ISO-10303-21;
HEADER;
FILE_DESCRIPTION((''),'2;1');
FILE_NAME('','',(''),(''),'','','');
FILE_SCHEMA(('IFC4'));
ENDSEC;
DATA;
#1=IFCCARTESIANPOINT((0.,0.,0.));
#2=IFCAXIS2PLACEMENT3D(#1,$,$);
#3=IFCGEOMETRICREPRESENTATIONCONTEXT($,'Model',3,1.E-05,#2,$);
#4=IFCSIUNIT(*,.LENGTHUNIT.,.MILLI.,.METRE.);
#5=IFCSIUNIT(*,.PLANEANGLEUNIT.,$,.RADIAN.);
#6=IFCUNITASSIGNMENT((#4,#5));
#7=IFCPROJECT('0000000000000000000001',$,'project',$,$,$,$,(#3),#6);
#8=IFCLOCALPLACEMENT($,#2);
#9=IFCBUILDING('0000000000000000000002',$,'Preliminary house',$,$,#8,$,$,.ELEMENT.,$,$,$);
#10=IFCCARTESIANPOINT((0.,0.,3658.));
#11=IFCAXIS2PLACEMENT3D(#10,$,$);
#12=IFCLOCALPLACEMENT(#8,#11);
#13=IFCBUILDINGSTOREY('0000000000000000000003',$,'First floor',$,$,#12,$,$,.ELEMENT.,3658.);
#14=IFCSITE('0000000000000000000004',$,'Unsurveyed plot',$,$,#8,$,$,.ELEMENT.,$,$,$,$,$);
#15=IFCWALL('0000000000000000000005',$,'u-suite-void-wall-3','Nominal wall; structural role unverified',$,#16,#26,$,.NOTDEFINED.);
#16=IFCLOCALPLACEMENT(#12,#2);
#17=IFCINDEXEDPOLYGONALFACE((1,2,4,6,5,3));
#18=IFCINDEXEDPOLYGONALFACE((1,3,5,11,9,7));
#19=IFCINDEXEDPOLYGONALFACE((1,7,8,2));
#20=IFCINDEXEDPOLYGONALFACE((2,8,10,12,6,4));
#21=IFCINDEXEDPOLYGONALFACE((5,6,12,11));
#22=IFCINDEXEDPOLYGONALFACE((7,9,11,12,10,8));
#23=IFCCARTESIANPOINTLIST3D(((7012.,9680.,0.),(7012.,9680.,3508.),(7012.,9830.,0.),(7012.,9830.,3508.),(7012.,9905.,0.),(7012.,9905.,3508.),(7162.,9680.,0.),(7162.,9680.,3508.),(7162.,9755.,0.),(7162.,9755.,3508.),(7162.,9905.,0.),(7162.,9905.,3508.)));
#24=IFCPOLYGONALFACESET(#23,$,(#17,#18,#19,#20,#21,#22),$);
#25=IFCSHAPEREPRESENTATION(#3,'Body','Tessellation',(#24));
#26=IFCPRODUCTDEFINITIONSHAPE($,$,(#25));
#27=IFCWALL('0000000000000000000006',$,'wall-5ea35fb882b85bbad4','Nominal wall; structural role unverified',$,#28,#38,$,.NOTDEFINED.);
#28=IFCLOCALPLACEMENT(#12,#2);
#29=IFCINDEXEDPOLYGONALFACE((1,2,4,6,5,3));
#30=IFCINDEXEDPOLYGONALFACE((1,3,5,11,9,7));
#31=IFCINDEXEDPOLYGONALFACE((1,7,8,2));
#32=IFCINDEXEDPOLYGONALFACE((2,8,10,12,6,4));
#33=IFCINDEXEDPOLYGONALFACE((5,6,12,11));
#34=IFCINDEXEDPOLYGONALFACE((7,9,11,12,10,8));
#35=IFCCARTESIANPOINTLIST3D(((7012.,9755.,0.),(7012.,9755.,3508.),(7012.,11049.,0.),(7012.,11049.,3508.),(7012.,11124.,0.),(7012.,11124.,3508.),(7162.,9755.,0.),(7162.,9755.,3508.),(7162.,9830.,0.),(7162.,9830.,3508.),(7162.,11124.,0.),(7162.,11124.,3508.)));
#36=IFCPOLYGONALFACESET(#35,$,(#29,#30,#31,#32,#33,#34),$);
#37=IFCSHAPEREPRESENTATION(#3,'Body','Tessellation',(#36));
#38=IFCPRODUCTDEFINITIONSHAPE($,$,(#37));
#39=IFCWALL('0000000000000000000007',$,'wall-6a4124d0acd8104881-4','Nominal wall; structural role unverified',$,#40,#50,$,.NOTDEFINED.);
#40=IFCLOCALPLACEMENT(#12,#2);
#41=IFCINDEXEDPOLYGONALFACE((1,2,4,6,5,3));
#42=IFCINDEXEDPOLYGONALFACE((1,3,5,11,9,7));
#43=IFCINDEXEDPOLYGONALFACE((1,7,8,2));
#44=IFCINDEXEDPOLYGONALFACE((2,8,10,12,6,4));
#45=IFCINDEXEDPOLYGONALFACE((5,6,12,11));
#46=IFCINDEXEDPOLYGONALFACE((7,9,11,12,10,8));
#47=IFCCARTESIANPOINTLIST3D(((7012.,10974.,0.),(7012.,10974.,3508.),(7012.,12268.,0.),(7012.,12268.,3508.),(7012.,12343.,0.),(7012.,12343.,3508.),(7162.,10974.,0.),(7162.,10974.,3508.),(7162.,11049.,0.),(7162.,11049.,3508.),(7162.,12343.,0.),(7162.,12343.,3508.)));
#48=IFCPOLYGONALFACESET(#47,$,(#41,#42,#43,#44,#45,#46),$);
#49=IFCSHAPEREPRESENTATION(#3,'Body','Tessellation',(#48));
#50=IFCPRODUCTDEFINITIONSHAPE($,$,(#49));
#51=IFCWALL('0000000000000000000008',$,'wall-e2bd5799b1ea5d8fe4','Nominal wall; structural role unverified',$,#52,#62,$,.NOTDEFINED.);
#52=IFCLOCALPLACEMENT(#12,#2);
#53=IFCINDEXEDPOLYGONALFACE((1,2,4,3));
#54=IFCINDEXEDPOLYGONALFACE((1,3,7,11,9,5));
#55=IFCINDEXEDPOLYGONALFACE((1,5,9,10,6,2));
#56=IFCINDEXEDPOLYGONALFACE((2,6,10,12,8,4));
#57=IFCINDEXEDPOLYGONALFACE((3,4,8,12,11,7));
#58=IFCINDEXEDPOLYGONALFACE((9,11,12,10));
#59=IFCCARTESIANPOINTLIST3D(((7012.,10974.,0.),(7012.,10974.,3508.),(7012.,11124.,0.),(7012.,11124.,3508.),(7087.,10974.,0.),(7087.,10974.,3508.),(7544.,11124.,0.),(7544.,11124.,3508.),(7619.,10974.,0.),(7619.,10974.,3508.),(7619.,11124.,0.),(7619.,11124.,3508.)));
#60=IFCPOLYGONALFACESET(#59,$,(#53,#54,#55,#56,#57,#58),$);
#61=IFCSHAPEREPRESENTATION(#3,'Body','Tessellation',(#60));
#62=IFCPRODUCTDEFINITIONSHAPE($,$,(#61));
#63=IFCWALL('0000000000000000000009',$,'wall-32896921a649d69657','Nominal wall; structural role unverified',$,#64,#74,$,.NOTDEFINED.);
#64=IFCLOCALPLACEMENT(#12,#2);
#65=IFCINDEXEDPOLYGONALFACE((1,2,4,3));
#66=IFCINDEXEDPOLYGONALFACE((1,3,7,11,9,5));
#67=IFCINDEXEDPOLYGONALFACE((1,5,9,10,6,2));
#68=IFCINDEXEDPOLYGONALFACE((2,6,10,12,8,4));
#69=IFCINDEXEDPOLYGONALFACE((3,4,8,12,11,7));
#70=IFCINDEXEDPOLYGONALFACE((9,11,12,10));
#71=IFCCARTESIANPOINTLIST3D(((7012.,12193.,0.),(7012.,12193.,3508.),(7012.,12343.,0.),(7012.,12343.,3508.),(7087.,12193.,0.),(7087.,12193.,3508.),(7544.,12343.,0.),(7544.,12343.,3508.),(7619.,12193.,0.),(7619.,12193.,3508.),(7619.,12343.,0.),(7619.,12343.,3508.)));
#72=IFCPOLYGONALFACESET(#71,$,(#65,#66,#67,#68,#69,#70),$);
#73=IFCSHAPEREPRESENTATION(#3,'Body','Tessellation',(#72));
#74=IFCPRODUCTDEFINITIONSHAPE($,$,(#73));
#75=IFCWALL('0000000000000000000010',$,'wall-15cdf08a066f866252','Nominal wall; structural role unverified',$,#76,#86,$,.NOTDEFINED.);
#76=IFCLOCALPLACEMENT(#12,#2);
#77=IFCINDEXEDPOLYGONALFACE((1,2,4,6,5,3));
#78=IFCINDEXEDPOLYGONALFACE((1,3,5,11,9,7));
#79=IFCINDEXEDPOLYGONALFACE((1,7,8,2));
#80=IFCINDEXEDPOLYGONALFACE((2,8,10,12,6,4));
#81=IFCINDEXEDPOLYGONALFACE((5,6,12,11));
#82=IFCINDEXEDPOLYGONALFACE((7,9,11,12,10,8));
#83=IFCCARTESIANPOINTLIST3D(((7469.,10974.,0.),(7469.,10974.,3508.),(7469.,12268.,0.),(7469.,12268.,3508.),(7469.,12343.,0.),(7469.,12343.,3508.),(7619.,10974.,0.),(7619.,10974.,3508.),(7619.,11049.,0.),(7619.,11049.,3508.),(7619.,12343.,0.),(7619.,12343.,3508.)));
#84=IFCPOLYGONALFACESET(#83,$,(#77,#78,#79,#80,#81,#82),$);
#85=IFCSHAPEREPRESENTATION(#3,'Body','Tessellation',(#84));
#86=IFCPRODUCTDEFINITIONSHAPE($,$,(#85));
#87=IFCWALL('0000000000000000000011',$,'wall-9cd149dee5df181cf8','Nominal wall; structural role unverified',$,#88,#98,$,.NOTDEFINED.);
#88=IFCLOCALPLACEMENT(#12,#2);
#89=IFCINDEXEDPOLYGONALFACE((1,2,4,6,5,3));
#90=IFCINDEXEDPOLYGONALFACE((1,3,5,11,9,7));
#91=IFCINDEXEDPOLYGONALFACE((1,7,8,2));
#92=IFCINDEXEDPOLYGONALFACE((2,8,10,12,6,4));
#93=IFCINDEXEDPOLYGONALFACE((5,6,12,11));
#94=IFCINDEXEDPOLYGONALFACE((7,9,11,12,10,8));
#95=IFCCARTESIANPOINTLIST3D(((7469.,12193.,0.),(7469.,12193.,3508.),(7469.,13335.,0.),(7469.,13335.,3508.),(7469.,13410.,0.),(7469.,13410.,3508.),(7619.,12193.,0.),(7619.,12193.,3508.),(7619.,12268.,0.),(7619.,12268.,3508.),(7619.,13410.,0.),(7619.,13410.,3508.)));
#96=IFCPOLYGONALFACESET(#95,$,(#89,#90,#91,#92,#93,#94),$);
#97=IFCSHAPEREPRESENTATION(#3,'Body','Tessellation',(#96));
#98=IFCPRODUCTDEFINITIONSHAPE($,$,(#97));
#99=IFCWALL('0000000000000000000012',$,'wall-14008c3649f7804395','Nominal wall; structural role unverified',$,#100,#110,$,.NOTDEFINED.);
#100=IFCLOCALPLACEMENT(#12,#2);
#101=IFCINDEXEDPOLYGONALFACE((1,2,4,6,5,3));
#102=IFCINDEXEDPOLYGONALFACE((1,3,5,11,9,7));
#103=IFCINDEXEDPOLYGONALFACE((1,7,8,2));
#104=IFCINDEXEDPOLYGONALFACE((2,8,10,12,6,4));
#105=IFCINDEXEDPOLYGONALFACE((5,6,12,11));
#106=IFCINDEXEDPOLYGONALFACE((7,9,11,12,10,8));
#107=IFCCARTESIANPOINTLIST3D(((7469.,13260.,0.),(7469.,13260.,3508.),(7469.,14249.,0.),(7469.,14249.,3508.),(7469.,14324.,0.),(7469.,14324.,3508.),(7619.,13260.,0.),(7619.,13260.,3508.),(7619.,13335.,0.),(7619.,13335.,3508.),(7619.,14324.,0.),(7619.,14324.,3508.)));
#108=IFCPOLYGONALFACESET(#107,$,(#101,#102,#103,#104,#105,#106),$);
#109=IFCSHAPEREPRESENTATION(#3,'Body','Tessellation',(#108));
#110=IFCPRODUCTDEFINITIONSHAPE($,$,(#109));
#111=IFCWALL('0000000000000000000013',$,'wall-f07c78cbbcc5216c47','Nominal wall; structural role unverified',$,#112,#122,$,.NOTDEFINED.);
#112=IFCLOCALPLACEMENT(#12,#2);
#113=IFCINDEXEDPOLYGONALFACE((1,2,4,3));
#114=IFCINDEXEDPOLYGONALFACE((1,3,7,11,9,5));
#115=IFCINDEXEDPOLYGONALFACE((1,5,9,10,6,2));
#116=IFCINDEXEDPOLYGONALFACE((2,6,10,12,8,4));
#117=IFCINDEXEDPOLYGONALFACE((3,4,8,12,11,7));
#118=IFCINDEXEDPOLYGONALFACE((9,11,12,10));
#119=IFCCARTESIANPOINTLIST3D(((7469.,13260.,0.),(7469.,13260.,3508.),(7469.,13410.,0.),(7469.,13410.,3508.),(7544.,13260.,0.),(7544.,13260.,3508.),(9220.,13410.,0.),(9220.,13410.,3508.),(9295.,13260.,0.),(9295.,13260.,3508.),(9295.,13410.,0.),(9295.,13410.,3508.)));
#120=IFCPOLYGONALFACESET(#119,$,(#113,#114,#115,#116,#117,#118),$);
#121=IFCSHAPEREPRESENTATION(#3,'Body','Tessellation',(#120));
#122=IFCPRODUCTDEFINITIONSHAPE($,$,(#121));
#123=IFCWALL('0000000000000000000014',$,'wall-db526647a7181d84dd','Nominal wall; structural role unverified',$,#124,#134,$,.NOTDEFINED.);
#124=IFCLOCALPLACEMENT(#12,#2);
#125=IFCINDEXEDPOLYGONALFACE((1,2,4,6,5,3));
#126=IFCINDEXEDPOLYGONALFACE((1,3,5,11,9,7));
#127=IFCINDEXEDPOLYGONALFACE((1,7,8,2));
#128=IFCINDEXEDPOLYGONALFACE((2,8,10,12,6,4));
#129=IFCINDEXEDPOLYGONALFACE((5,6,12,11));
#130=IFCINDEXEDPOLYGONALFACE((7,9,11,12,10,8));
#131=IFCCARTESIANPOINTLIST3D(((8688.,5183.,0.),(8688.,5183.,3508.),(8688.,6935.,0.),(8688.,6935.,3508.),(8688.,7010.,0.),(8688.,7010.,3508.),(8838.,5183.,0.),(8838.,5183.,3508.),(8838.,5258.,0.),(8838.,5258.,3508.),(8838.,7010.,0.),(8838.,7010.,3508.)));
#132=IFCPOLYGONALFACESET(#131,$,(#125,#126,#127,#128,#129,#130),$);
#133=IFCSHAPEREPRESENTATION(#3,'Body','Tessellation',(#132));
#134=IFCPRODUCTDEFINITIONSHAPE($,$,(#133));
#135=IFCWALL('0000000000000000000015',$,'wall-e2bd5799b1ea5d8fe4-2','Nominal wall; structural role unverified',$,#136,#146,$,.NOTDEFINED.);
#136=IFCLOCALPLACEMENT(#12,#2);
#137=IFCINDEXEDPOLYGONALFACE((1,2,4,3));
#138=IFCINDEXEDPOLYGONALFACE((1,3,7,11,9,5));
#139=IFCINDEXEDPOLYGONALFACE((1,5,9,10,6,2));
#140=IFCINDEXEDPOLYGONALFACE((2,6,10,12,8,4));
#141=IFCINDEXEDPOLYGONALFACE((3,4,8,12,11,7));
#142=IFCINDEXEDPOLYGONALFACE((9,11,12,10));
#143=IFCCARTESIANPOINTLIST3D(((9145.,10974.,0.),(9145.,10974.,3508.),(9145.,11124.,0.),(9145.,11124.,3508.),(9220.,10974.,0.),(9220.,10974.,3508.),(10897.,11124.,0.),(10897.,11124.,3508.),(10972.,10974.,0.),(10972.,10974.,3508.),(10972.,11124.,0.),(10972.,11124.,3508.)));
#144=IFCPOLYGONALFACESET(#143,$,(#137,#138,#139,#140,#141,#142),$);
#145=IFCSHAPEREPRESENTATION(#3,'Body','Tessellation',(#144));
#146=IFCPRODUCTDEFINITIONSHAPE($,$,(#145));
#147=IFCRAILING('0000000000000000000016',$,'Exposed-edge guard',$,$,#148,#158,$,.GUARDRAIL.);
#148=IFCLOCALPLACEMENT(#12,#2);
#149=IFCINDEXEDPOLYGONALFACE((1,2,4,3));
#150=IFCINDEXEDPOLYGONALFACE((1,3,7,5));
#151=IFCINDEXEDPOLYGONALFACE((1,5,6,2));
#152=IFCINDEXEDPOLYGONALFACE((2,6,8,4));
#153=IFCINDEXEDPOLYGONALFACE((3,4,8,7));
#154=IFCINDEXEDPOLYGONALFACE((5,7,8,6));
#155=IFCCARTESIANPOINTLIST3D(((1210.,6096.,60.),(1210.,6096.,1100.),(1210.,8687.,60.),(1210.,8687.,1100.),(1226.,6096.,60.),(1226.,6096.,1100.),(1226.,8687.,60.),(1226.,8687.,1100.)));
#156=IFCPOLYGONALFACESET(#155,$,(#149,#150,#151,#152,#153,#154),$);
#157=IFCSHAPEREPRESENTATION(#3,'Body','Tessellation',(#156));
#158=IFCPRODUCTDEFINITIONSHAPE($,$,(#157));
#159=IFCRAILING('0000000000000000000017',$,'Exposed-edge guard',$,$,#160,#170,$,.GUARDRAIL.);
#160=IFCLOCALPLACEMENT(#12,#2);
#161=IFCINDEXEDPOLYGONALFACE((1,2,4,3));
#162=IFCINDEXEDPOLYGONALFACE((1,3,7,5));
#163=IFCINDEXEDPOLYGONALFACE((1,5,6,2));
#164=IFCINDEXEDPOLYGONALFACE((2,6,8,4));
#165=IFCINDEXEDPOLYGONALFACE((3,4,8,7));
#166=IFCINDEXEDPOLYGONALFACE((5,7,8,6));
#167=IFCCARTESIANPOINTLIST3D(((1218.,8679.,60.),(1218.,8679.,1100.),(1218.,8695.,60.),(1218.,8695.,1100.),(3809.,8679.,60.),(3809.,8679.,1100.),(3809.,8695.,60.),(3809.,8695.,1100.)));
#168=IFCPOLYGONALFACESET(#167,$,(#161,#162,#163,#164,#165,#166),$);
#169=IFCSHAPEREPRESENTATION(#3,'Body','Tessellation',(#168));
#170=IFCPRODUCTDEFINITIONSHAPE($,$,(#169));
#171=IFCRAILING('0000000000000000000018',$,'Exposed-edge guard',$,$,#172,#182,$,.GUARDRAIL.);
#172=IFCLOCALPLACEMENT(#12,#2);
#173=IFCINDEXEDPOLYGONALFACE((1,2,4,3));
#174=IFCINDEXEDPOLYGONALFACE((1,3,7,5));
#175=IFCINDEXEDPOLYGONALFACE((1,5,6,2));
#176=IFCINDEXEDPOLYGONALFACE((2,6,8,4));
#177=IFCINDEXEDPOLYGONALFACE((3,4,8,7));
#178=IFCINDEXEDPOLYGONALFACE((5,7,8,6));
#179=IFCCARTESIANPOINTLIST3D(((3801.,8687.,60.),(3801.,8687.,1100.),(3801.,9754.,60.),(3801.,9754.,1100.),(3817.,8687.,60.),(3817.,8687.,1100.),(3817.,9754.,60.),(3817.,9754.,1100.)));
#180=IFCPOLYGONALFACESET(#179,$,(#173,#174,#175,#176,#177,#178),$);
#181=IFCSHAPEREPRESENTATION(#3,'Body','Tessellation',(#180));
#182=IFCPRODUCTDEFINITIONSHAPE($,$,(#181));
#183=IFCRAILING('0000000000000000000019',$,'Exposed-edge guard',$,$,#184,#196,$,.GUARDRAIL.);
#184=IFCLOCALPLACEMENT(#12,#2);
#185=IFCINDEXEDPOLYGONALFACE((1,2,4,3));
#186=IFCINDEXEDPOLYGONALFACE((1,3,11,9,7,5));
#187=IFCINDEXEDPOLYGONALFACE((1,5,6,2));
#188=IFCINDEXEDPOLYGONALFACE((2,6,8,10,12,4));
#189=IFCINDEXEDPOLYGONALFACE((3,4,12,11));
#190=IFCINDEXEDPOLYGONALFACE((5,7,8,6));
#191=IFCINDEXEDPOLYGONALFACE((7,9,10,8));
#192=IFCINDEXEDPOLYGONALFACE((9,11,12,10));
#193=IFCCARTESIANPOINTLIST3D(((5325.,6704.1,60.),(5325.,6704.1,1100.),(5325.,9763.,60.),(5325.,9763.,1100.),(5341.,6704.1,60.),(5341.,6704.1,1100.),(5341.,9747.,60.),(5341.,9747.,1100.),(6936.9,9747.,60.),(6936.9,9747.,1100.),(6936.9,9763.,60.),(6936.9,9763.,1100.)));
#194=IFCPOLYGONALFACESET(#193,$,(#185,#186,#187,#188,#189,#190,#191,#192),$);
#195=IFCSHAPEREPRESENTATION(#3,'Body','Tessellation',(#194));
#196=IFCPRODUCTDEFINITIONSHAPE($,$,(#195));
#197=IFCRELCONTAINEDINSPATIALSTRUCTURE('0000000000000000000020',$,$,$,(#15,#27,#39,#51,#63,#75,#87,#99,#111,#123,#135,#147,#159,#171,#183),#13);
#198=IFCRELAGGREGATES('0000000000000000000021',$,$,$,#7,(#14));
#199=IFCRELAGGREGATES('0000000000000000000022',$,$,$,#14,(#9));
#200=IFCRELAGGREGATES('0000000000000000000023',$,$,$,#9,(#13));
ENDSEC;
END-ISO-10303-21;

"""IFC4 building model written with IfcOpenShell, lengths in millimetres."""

from ifc_helpers import new_model, si_unit, frame, origin, place, context, project, spatial, polyline, outline, extrude, element, save


model = new_model("IFC4")

# Units and contexts
model_context = context("Model", 3, precision=1e-05, world=origin())
ifc_project = project(units=[si_unit("LENGTHUNIT", "METRE", prefix="MILLI"), si_unit("PLANEANGLEUNIT", "RADIAN")], contexts=[model_context])

# Site, building, storey
placement_1 = place(None, origin())
site = spatial("IfcSite", under=ifc_project, at=placement_1, Name="Unsurveyed plot", CompositionType="ELEMENT")
building = spatial("IfcBuilding", under=site, at=placement_1, Name="Preliminary house", CompositionType="ELEMENT")
placement_2 = place(placement_1, frame((0.0, 0.0, 3658.0)))
storey = spatial("IfcBuildingStorey", under=building, at=placement_2, Name="First floor", CompositionType="ELEMENT", Elevation=3658.0)

# Walls
element("IfcWall", 1, at=placement_2, inside=storey, Name="u-suite-void-wall-3", Description="Nominal wall; structural role unverified", PredefinedType="NOTDEFINED", context=model_context, shape_type="SweptSolid", body=[
    extrude(outline(polyline([(7012.0, 9830.0), (7012.0, 9905.0), (7162.0, 9905.0), (7162.0, 9755.0), (7162.0, 9680.0), (7012.0, 9680.0), (7012.0, 9830.0)])), origin(), (0.0, 0.0, 1.0), 3508.0),
])
element("IfcWall", 2, at=placement_2, inside=storey, Name="wall-5ea35fb882b85bbad4", Description="Nominal wall; structural role unverified", PredefinedType="NOTDEFINED", context=model_context, shape_type="SweptSolid", body=[
    extrude(outline(polyline([(7012.0, 11049.0), (7012.0, 11124.0), (7162.0, 11124.0), (7162.0, 9830.0), (7162.0, 9755.0), (7012.0, 9755.0), (7012.0, 11049.0)])), origin(), (0.0, 0.0, 1.0), 3508.0),
])
element("IfcWall", 3, at=placement_2, inside=storey, Name="wall-6a4124d0acd8104881-4", Description="Nominal wall; structural role unverified", PredefinedType="NOTDEFINED", context=model_context, shape_type="SweptSolid", body=[
    extrude(outline(polyline([(7012.0, 12268.0), (7012.0, 12343.0), (7162.0, 12343.0), (7162.0, 11049.0), (7162.0, 10974.0), (7012.0, 10974.0), (7012.0, 12268.0)])), origin(), (0.0, 0.0, 1.0), 3508.0),
])
element("IfcWall", 4, at=placement_2, inside=storey, Name="wall-e2bd5799b1ea5d8fe4", Description="Nominal wall; structural role unverified", PredefinedType="NOTDEFINED", context=model_context, shape_type="SweptSolid", body=[
    extrude(outline(polyline([(7544.0, 11124.0), (7619.0, 11124.0), (7619.0, 10974.0), (7087.0, 10974.0), (7012.0, 10974.0), (7012.0, 11124.0), (7544.0, 11124.0)])), origin(), (0.0, 0.0, 1.0), 3508.0),
])
element("IfcWall", 5, at=placement_2, inside=storey, Name="wall-32896921a649d69657", Description="Nominal wall; structural role unverified", PredefinedType="NOTDEFINED", context=model_context, shape_type="SweptSolid", body=[
    extrude(outline(polyline([(7544.0, 12343.0), (7619.0, 12343.0), (7619.0, 12193.0), (7087.0, 12193.0), (7012.0, 12193.0), (7012.0, 12343.0), (7544.0, 12343.0)])), origin(), (0.0, 0.0, 1.0), 3508.0),
])
element("IfcWall", 6, at=placement_2, inside=storey, Name="wall-15cdf08a066f866252", Description="Nominal wall; structural role unverified", PredefinedType="NOTDEFINED", context=model_context, shape_type="SweptSolid", body=[
    extrude(outline(polyline([(7469.0, 12268.0), (7469.0, 12343.0), (7619.0, 12343.0), (7619.0, 11049.0), (7619.0, 10974.0), (7469.0, 10974.0), (7469.0, 12268.0)])), origin(), (0.0, 0.0, 1.0), 3508.0),
])

# Walls
element("IfcWall", 7, at=placement_2, inside=storey, Name="wall-9cd149dee5df181cf8", Description="Nominal wall; structural role unverified", PredefinedType="NOTDEFINED", context=model_context, shape_type="SweptSolid", body=[
    extrude(outline(polyline([(7469.0, 13335.0), (7469.0, 13410.0), (7619.0, 13410.0), (7619.0, 12268.0), (7619.0, 12193.0), (7469.0, 12193.0), (7469.0, 13335.0)])), origin(), (0.0, 0.0, 1.0), 3508.0),
])
element("IfcWall", 8, at=placement_2, inside=storey, Name="wall-14008c3649f7804395", Description="Nominal wall; structural role unverified", PredefinedType="NOTDEFINED", context=model_context, shape_type="SweptSolid", body=[
    extrude(outline(polyline([(7469.0, 14249.0), (7469.0, 14324.0), (7619.0, 14324.0), (7619.0, 13335.0), (7619.0, 13260.0), (7469.0, 13260.0), (7469.0, 14249.0)])), origin(), (0.0, 0.0, 1.0), 3508.0),
])
element("IfcWall", 9, at=placement_2, inside=storey, Name="wall-f07c78cbbcc5216c47", Description="Nominal wall; structural role unverified", PredefinedType="NOTDEFINED", context=model_context, shape_type="SweptSolid", body=[
    extrude(outline(polyline([(9220.0, 13410.0), (9295.0, 13410.0), (9295.0, 13260.0), (7544.0, 13260.0), (7469.0, 13260.0), (7469.0, 13410.0), (9220.0, 13410.0)])), origin(), (0.0, 0.0, 1.0), 3508.0),
])
element("IfcWall", 10, at=placement_2, inside=storey, Name="wall-db526647a7181d84dd", Description="Nominal wall; structural role unverified", PredefinedType="NOTDEFINED", context=model_context, shape_type="SweptSolid", body=[
    extrude(outline(polyline([(8688.0, 6935.0), (8688.0, 7010.0), (8838.0, 7010.0), (8838.0, 5258.0), (8838.0, 5183.0), (8688.0, 5183.0), (8688.0, 6935.0)])), origin(), (0.0, 0.0, 1.0), 3508.0),
])

# Wall
element("IfcWall", 11, at=placement_2, inside=storey, Name="wall-e2bd5799b1ea5d8fe4-2", Description="Nominal wall; structural role unverified", PredefinedType="NOTDEFINED", context=model_context, shape_type="SweptSolid", body=[
    extrude(outline(polyline([(10897.0, 11124.0), (10972.0, 11124.0), (10972.0, 10974.0), (9220.0, 10974.0), (9145.0, 10974.0), (9145.0, 11124.0), (10897.0, 11124.0)])), origin(), (0.0, 0.0, 1.0), 3508.0),
])

# Railings
element("IfcRailing", 12, at=placement_2, inside=storey, Name="Exposed-edge guard", PredefinedType="GUARDRAIL", context=model_context, shape_type="SweptSolid", body=[
    extrude(outline(polyline([(1210.0, 8687.0), (1226.0, 8687.0), (1226.0, 6096.0), (1210.0, 6096.0), (1210.0, 8687.0)])), frame((0.0, 0.0, 60.0)), (0.0, 0.0, 1.0), 1040.0),
])
element("IfcRailing", 13, at=placement_2, inside=storey, Name="Exposed-edge guard", PredefinedType="GUARDRAIL", context=model_context, shape_type="SweptSolid", body=[
    extrude(outline(polyline([(3809.0, 8695.0), (3809.0, 8679.0), (1218.0, 8679.0), (1218.0, 8695.0), (3809.0, 8695.0)])), frame((0.0, 0.0, 60.0)), (0.0, 0.0, 1.0), 1040.0),
])
element("IfcRailing", 14, at=placement_2, inside=storey, Name="Exposed-edge guard", PredefinedType="GUARDRAIL", context=model_context, shape_type="SweptSolid", body=[
    extrude(outline(polyline([(3801.0, 9754.0), (3817.0, 9754.0), (3817.0, 8687.0), (3801.0, 8687.0), (3801.0, 9754.0)])), frame((0.0, 0.0, 60.0)), (0.0, 0.0, 1.0), 1040.0),
])
element("IfcRailing", 15, at=placement_2, inside=storey, Name="Exposed-edge guard", PredefinedType="GUARDRAIL", context=model_context, shape_type="SweptSolid", body=[
    extrude(outline(polyline([(5341.0, 9747.0), (5341.0, 6704.1), (5325.0, 6704.1), (5325.0, 9763.0), (6936.9, 9763.0), (6936.9, 9747.0), (5341.0, 9747.0)])), frame((0.0, 0.0, 60.0)), (0.0, 0.0, 1.0), 1040.0),
])

save(model, "model.ifc")
